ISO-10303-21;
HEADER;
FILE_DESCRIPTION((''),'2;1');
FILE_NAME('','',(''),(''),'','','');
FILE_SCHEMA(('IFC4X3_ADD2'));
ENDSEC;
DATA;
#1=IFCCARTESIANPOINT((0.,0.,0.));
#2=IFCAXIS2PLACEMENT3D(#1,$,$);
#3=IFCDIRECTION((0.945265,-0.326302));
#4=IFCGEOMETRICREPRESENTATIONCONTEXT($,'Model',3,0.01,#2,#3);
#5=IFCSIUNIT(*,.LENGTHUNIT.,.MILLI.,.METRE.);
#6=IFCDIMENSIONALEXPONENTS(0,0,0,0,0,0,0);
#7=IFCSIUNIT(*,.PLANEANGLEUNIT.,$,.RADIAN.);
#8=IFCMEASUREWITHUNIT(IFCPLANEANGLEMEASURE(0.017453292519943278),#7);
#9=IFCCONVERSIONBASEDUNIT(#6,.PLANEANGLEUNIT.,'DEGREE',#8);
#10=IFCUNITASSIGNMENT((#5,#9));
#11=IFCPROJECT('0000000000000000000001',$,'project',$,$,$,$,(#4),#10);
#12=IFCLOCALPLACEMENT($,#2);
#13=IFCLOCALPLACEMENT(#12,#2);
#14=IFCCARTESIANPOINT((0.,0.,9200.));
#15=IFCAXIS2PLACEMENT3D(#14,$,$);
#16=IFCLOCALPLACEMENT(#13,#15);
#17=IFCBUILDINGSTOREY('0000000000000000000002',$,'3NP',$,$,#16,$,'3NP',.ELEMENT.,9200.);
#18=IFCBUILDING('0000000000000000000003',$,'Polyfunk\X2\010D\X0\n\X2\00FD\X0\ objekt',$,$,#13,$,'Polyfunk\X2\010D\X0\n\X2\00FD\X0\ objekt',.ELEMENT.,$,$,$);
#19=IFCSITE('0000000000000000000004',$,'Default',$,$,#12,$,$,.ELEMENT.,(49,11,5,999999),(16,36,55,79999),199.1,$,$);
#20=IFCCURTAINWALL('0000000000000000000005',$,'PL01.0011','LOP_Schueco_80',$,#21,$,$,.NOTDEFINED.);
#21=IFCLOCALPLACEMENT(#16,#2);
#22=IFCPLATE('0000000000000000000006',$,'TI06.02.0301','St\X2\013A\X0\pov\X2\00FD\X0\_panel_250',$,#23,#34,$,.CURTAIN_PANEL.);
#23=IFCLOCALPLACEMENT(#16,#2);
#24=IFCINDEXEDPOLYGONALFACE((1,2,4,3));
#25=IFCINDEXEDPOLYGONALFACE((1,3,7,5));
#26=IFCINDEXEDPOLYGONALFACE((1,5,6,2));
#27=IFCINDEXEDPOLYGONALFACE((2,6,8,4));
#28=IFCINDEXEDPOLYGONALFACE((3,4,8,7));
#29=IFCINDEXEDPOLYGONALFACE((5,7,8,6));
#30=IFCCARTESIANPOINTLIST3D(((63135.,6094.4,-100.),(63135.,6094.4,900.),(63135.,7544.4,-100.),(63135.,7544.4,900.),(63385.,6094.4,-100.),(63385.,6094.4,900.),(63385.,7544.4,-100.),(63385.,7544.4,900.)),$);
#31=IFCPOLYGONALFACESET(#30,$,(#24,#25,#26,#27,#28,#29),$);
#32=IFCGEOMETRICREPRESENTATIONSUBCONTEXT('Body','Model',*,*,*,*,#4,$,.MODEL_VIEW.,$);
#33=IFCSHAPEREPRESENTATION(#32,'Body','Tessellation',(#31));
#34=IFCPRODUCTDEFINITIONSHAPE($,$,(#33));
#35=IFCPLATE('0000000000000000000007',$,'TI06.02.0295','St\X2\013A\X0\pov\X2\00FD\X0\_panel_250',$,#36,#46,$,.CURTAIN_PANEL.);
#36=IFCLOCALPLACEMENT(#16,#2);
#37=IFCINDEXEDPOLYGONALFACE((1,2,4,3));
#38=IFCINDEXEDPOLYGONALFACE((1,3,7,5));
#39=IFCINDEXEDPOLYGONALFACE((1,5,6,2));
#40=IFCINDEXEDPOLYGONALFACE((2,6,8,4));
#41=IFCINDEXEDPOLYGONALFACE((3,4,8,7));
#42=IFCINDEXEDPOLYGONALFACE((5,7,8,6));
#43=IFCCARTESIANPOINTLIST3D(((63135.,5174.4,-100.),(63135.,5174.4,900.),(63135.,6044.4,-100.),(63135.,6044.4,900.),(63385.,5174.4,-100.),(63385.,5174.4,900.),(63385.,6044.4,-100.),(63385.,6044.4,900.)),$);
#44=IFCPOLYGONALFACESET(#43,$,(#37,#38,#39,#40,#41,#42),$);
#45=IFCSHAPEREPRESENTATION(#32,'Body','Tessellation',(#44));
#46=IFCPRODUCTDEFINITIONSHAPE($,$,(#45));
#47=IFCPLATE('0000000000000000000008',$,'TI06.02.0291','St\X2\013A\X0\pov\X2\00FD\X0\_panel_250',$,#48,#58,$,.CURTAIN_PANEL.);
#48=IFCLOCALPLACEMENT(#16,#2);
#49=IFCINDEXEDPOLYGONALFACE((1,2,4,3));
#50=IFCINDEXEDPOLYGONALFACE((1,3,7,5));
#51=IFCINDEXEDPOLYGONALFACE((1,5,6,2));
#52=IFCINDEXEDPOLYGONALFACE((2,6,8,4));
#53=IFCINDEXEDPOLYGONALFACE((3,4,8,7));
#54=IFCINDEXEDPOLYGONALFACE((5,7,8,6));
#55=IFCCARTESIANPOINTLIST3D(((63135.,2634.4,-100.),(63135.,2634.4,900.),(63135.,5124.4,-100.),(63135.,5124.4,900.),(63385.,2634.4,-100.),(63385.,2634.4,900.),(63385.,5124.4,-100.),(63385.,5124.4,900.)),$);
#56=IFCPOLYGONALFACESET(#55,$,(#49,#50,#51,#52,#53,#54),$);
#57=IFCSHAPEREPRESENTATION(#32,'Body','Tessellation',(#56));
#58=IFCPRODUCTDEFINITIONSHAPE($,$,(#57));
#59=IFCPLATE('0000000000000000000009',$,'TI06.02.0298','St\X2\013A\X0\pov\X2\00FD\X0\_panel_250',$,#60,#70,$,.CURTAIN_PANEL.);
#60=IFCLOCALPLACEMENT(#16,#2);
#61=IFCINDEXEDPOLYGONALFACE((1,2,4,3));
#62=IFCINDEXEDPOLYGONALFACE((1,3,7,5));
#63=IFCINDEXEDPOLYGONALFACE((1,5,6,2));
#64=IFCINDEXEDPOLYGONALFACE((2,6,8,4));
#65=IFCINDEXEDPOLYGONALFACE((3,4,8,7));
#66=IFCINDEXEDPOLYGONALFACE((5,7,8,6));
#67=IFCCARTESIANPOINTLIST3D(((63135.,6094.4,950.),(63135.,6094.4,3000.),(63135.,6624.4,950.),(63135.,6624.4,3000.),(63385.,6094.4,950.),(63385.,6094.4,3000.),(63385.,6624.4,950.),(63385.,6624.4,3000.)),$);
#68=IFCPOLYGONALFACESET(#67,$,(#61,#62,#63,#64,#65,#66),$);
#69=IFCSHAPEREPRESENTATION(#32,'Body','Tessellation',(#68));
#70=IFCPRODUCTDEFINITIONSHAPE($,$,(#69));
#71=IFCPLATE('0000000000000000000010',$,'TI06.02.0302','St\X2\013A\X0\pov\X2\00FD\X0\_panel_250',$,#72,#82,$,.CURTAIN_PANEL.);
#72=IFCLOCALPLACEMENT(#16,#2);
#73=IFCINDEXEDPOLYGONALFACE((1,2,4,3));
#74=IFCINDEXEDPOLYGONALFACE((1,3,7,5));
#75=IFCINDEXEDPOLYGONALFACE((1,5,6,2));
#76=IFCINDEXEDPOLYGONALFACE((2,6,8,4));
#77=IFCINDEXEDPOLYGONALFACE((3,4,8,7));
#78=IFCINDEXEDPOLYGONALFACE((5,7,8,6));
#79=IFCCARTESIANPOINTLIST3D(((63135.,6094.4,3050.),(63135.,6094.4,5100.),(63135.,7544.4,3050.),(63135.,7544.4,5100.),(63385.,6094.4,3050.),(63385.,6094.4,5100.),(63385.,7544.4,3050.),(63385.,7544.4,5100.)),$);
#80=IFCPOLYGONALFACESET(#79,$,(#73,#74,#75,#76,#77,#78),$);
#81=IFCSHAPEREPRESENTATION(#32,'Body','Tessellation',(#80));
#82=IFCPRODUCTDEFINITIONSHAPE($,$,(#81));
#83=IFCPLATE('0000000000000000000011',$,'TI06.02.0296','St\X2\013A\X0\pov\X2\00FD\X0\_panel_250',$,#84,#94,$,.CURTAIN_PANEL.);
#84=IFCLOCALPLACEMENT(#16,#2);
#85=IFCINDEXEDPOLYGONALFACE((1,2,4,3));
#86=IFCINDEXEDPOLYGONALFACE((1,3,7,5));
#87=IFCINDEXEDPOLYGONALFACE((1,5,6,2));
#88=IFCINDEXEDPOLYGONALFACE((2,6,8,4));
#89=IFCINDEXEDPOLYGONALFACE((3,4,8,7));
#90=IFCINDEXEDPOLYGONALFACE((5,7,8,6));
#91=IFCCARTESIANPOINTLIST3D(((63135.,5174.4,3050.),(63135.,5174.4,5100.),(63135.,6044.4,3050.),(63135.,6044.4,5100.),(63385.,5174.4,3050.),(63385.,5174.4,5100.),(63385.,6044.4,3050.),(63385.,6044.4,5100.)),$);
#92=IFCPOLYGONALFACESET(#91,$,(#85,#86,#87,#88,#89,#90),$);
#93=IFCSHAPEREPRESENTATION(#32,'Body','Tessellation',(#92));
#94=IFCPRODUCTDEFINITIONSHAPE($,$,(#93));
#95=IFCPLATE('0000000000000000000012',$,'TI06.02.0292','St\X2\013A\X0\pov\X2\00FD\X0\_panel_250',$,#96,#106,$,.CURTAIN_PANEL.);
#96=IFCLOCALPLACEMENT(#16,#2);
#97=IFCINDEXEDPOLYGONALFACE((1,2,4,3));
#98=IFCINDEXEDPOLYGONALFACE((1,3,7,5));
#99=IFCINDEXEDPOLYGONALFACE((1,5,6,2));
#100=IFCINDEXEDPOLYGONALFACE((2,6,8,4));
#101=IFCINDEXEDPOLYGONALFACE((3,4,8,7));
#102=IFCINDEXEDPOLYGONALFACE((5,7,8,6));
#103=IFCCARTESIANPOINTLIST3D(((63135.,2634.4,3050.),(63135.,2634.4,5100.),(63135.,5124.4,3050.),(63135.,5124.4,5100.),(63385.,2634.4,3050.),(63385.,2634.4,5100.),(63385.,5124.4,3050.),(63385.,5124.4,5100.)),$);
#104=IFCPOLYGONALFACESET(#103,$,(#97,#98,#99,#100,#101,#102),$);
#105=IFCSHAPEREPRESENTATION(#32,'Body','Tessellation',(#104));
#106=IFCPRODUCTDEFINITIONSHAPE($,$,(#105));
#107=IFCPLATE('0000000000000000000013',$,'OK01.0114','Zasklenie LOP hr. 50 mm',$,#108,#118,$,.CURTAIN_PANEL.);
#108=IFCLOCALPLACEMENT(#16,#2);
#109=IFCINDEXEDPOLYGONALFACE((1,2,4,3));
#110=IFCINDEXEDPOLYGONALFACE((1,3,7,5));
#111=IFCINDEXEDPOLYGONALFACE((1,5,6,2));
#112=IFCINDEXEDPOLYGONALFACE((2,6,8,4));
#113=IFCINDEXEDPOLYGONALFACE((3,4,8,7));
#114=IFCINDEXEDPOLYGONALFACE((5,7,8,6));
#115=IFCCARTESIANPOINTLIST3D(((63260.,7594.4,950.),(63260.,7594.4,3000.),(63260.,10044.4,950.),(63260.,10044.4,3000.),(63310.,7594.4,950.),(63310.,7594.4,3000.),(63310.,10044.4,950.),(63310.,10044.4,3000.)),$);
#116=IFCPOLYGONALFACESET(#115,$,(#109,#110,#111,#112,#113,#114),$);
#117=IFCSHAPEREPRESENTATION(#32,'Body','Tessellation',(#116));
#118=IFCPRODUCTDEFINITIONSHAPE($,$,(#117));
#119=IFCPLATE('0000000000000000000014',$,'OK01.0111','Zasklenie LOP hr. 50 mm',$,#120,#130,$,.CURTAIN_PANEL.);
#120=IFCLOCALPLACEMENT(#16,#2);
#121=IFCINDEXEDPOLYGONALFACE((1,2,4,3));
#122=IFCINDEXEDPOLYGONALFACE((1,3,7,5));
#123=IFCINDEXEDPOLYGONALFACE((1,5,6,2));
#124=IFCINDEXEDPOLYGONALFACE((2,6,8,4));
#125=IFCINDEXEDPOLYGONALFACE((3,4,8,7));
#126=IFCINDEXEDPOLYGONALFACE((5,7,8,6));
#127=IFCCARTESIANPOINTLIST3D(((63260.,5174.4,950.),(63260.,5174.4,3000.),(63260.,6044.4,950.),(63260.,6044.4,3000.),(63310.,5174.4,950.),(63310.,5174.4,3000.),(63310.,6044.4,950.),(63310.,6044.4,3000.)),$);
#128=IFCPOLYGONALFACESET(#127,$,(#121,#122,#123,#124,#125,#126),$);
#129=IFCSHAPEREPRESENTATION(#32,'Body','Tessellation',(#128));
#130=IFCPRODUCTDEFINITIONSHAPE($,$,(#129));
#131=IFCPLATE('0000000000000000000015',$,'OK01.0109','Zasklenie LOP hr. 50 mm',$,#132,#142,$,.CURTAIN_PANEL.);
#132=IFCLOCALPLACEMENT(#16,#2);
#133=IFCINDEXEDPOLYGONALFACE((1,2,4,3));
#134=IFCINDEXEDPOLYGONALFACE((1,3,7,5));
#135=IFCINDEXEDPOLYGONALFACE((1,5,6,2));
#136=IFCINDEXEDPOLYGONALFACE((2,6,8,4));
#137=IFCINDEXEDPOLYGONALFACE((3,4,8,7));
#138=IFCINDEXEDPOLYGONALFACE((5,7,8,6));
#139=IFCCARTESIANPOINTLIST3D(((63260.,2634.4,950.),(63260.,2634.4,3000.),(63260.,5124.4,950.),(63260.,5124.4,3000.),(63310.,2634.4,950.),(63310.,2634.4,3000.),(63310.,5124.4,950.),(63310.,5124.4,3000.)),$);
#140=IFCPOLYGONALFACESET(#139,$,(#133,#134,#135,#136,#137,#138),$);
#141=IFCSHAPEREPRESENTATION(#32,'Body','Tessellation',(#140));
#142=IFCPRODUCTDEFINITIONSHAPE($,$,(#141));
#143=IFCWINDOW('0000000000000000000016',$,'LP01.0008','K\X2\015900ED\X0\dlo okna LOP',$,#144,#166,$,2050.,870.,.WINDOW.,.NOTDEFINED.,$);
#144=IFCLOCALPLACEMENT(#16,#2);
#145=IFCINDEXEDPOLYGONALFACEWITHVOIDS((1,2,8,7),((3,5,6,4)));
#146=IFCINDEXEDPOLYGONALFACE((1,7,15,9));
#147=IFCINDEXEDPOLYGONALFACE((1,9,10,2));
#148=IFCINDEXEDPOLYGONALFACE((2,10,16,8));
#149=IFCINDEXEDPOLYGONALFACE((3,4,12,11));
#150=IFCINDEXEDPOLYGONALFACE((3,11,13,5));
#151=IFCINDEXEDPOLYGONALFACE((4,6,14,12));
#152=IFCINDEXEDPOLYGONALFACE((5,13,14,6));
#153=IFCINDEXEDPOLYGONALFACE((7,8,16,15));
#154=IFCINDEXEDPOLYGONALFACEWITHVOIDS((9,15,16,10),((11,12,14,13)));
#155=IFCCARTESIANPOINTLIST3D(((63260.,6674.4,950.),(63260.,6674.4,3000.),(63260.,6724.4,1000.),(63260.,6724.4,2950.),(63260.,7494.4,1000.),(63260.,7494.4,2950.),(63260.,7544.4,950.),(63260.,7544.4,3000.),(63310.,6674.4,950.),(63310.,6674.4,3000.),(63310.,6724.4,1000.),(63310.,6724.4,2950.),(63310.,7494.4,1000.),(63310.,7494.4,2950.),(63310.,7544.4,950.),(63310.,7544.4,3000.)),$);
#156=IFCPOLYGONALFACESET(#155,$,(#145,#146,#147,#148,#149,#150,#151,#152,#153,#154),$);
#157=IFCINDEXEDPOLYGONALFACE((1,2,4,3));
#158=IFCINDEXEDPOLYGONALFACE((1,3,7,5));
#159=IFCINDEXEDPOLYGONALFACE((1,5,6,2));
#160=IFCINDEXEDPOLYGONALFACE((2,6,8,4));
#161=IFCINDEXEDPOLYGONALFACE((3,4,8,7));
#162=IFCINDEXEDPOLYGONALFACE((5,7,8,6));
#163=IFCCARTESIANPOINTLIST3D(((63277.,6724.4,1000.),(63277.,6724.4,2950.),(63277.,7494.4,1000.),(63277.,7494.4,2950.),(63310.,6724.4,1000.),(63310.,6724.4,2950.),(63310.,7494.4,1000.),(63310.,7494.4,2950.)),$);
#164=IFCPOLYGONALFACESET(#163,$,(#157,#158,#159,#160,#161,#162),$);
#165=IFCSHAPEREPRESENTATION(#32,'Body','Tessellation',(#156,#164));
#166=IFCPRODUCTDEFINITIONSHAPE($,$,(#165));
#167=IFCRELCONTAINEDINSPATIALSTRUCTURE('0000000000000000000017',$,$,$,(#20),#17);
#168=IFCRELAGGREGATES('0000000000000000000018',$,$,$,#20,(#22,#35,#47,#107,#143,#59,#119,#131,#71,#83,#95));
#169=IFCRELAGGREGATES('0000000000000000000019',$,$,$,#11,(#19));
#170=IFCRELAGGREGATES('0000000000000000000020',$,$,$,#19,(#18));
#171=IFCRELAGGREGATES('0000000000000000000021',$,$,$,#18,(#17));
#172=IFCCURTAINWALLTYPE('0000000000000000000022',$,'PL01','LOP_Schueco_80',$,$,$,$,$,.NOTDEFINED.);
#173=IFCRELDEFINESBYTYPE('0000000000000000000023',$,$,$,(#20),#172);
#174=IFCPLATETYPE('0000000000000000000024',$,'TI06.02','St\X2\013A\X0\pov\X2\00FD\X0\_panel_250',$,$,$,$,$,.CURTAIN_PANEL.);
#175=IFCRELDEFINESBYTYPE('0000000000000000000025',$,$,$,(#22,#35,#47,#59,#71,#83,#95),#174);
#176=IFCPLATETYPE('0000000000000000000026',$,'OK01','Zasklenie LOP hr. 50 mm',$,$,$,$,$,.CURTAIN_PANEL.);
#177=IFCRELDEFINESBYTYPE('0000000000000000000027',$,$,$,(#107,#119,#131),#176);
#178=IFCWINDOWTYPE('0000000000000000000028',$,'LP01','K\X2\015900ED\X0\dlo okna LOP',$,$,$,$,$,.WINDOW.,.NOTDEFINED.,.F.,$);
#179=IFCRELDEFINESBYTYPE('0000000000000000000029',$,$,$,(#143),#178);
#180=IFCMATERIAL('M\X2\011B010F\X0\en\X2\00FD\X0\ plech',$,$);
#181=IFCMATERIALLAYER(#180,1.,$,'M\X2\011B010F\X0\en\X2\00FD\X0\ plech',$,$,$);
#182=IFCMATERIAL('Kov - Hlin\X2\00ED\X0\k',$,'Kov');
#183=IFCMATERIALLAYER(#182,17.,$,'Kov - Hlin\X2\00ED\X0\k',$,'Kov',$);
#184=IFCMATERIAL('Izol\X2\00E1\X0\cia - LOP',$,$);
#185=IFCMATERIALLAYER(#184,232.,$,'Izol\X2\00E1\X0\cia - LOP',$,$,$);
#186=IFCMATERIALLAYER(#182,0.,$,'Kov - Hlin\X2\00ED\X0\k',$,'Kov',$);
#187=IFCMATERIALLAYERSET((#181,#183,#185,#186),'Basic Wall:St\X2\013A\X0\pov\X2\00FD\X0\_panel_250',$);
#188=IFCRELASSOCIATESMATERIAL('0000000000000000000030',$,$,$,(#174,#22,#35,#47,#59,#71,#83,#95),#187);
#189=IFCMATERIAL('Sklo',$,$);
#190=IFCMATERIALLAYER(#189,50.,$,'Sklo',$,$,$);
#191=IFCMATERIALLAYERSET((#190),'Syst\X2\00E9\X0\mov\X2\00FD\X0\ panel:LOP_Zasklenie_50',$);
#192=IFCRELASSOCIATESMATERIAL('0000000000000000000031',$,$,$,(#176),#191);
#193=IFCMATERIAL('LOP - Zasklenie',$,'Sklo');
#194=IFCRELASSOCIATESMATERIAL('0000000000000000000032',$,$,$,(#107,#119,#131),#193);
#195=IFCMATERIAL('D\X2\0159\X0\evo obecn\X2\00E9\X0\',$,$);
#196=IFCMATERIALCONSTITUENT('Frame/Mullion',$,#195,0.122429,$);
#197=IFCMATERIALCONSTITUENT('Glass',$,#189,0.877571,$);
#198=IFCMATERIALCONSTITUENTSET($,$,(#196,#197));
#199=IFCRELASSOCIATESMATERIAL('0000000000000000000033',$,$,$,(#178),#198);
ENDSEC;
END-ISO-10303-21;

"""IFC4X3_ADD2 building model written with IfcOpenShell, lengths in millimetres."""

from ifc_helpers import new_model, entity, si_unit, converted_unit, direction, frame, frame_2d, origin, origin_2d_with_axis, place, context, subcontext, project, spatial, polyline, rectangle, outline, extrude, source, transform, mapped, material, layer, layer_set, layer_usage, constituent, constituent_set, type_object, type_shapes, element, aggregate, save


model = new_model("IFC4X3_ADD2")

# Units and contexts
model_context = context("Model", 3, precision=0.01, world=origin(), true_north=direction((0.945265, -0.326302)))
body_context = subcontext(model_context, "Body", "Model", "MODEL_VIEW")
ifc_project = project(units=[si_unit("LENGTHUNIT", "METRE", prefix="MILLI"), converted_unit("PLANEANGLEUNIT", "DEGREE", entity("IfcPlaneAngleMeasure", 0.017453292519943278), si_unit("PLANEANGLEUNIT", "RADIAN"), dimensions=[0, 0, 0, 0, 0, 0, 0])], contexts=[model_context])

# Site, building, storey
site_placement = place(None, origin())
site = spatial("IfcSite", under=ifc_project, at=site_placement, Name="Default", CompositionType="ELEMENT", RefLatitude=(49, 11, 5, 999999), RefLongitude=(16, 36, 55, 79999), RefElevation=199.1)
building_placement = place(site_placement, origin())
building = spatial("IfcBuilding", under=site, at=building_placement, Name="Polyfunkčný objekt", LongName="Polyfunkčný objekt", CompositionType="ELEMENT")
storey_placement = place(building_placement, frame((0.0, 0.0, 9200.0)))
storey = spatial("IfcBuildingStorey", under=building, at=storey_placement, Name="3NP", LongName="3NP", CompositionType="ELEMENT", Elevation=9200.0)

# Curtain wall, plates, window
curtain_wall_type = type_object("IfcCurtainWallType", Name="PL01", Description="LOP_Schueco_80", PredefinedType="NOTDEFINED")
curtain_wall_placement = place(storey_placement, frame((0.0, 0.0, -9200.0)))
curtain_wall = element("IfcCurtainWall", 1, at=curtain_wall_placement, inside=storey, type_object=curtain_wall_type, Name="PL01.0011", Description="LOP_Schueco_80", PredefinedType="NOTDEFINED")
ifc_material_1 = material(Name="Měďený plech")
ifc_layer_1 = layer(ifc_material_1, 1.0, Name="Měďený plech")
ifc_material_2 = material(Name="Kov - Hliník", Category="Kov")
ifc_layer_2 = layer(ifc_material_2, 17.0, Name="Kov - Hliník", Category="Kov")
ifc_material_3 = material(Name="Izolácia - LOP")
ifc_layer_3 = layer(ifc_material_3, 232.0, Name="Izolácia - LOP")
ifc_layer_4 = layer(ifc_material_2, 0.0, Name="Kov - Hliník", Category="Kov")
ifc_layer_set_1 = layer_set([ifc_layer_1, ifc_layer_2, ifc_layer_3, ifc_layer_4], Name="Basic Wall:Stĺpový_panel_250")
ifc_layer_usage_1 = layer_usage(ifc_layer_set_1, "AXIS2", "NEGATIVE", 125.0)
plate_type_1 = type_object("IfcPlateType", Name="TI06.02", Description="Stĺpový_panel_250", PredefinedType="CURTAIN_PANEL", material=ifc_layer_set_1)
plate_1_placement = place(storey_placement, frame((63260.0, 7544.4, -100.0), z_axis=(0.0, 0.0, 1.0), x_axis=(0.0, -1.0, 0.0)))
plate_1 = element("IfcPlate", 2, at=plate_1_placement, type_object=plate_type_1, material=ifc_layer_usage_1, Name="TI06.02.0301", Description="Stĺpový_panel_250", PredefinedType="CURTAIN_PANEL", context=body_context, shape_type="SweptSolid", body=[
    extrude(rectangle(XDim=250.0, YDim=1450.0, at=frame_2d((0.0, 0.0), x_axis=(1.0, 0.0))), frame((725.0, 0.0, 0.0), z_axis=(0.0, 0.0, 1.0), x_axis=(0.0, 1.0, 0.0)), (0.0, 0.0, 1.0), 1000.0),
])
ifc_layer_usage_2 = layer_usage(ifc_layer_set_1, "AXIS2", "NEGATIVE", 125.0)
plate_2_placement = place(storey_placement, frame((63260.0, 6044.4, -100.0), z_axis=(0.0, 0.0, 1.0), x_axis=(0.0, -1.0, 0.0)))
plate_2 = element("IfcPlate", 3, at=plate_2_placement, type_object=plate_type_1, material=ifc_layer_usage_2, Name="TI06.02.0295", Description="Stĺpový_panel_250", PredefinedType="CURTAIN_PANEL", context=body_context, shape_type="SweptSolid", body=[
    extrude(rectangle(XDim=250.0, YDim=870.0, at=frame_2d((0.0, 0.0), x_axis=(1.0, 0.0))), frame((435.0, 0.0, 0.0), z_axis=(0.0, 0.0, 1.0), x_axis=(0.0, 1.0, 0.0)), (0.0, 0.0, 1.0), 1000.0),
])
ifc_layer_usage_3 = layer_usage(ifc_layer_set_1, "AXIS2", "NEGATIVE", 125.0)
plate_3_placement = place(storey_placement, frame((63260.0, 5124.4, -100.0), z_axis=(0.0, 0.0, 1.0), x_axis=(0.0, -1.0, 0.0)))
plate_3 = element("IfcPlate", 4, at=plate_3_placement, type_object=plate_type_1, material=ifc_layer_usage_3, Name="TI06.02.0291", Description="Stĺpový_panel_250", PredefinedType="CURTAIN_PANEL", context=body_context, shape_type="SweptSolid", body=[
    extrude(rectangle(XDim=250.0, YDim=2490.0, at=origin_2d_with_axis()), frame((1245.0, 0.0, 0.0), z_axis=(0.0, 0.0, 1.0), x_axis=(0.0, 1.0, 0.0)), (0.0, 0.0, 1.0), 1000.0),
])
ifc_layer_usage_4 = layer_usage(ifc_layer_set_1, "AXIS2", "NEGATIVE", 125.0)
plate_4_placement = place(storey_placement, frame((63260.0, 6624.4, 950.0), z_axis=(0.0, 0.0, 1.0), x_axis=(0.0, -1.0, 0.0)))
plate_4 = element("IfcPlate", 5, at=plate_4_placement, type_object=plate_type_1, material=ifc_layer_usage_4, Name="TI06.02.0298", Description="Stĺpový_panel_250", PredefinedType="CURTAIN_PANEL", context=body_context, shape_type="SweptSolid", body=[
    extrude(rectangle(XDim=250.0, YDim=530.0, at=frame_2d((0.0, 0.0), x_axis=(1.0, 0.0))), frame((265.0, 0.0, 0.0), z_axis=(0.0, 0.0, 1.0), x_axis=(0.0, 1.0, 0.0)), (0.0, 0.0, 1.0), 2050.0),
])
ifc_layer_usage_5 = layer_usage(ifc_layer_set_1, "AXIS2", "NEGATIVE", 125.0)
plate_5_placement = place(storey_placement, frame((63260.0, 7544.4, 3050.0), z_axis=(0.0, 0.0, 1.0), x_axis=(0.0, -1.0, 0.0)))
plate_5 = element("IfcPlate", 6, at=plate_5_placement, type_object=plate_type_1, material=ifc_layer_usage_5, Name="TI06.02.0302", Description="Stĺpový_panel_250", PredefinedType="CURTAIN_PANEL", context=body_context, shape_type="SweptSolid", body=[
    extrude(rectangle(XDim=250.0, YDim=1450.0, at=frame_2d((0.0, 0.0), x_axis=(1.0, 0.0))), frame((725.0, 0.0, 0.0), z_axis=(0.0, 0.0, 1.0), x_axis=(0.0, 1.0, 0.0)), (0.0, 0.0, 1.0), 2050.0),
])
ifc_layer_usage_6 = layer_usage(ifc_layer_set_1, "AXIS2", "NEGATIVE", 125.0)
plate_6_placement = place(storey_placement, frame((63260.0, 6044.4, 3050.0), z_axis=(0.0, 0.0, 1.0), x_axis=(0.0, -1.0, 0.0)))
plate_6 = element("IfcPlate", 7, at=plate_6_placement, type_object=plate_type_1, material=ifc_layer_usage_6, Name="TI06.02.0296", Description="Stĺpový_panel_250", PredefinedType="CURTAIN_PANEL", context=body_context, shape_type="SweptSolid", body=[
    extrude(rectangle(XDim=250.0, YDim=870.0, at=frame_2d((0.0, 0.0), x_axis=(1.0, 0.0))), frame((435.0, 0.0, 0.0), z_axis=(0.0, 0.0, 1.0), x_axis=(0.0, 1.0, 0.0)), (0.0, 0.0, 1.0), 2050.0),
])
ifc_layer_usage_7 = layer_usage(ifc_layer_set_1, "AXIS2", "NEGATIVE", 125.0)
plate_7_placement = place(storey_placement, frame((63260.0, 5124.4, 3050.0), z_axis=(0.0, 0.0, 1.0), x_axis=(0.0, -1.0, 0.0)))
plate_7 = element("IfcPlate", 8, at=plate_7_placement, type_object=plate_type_1, material=ifc_layer_usage_7, Name="TI06.02.0292", Description="Stĺpový_panel_250", PredefinedType="CURTAIN_PANEL", context=body_context, shape_type="SweptSolid", body=[
    extrude(rectangle(XDim=250.0, YDim=2490.0, at=frame_2d((0.0, 0.0), x_axis=(1.0, 0.0))), frame((1245.0, 0.0, 0.0), z_axis=(0.0, 0.0, 1.0), x_axis=(0.0, 1.0, 0.0)), (0.0, 0.0, 1.0), 2050.0),
])
ifc_material_4 = material(Name="LOP - Zasklenie", Category="Sklo")
ifc_material_5 = material(Name="Sklo")
ifc_layer_5 = layer(ifc_material_5, 50.0, Name="Sklo")
ifc_layer_set_2 = layer_set([ifc_layer_5], Name="Systémový panel:LOP_Zasklenie_50")
plate_type_2 = type_object("IfcPlateType", Name="OK01", Description="Zasklenie LOP hr. 50 mm", PredefinedType="CURTAIN_PANEL", material=ifc_layer_set_2)
shared_shape_1 = source(origin(), body_context, "Body", "SweptSolid", [
    extrude(rectangle(XDim=50.0, YDim=2450.0, at=origin_2d_with_axis()), frame((0.0, 25.0, 0.0), z_axis=(0.0, 0.0, 1.0), x_axis=(0.0, 1.0, 0.0)), (0.0, 0.0, 1.0), 2050.0),
])
plate_8_placement = place(curtain_wall_placement, frame((63260.0, 8819.4, 10150.0), z_axis=(0.0, 0.0, 1.0), x_axis=(0.0, -1.0, 0.0)))
plate_8 = element("IfcPlate", 9, at=plate_8_placement, type_object=plate_type_2, material=ifc_material_4, Name="OK01.0114", Description="Zasklenie LOP hr. 50 mm", PredefinedType="CURTAIN_PANEL", context=body_context, shape_type="MappedRepresentation", body=[
    mapped(shared_shape_1, transform((0.0, 0.0, 0.0), scale=1.0)),
])
shared_shape_2 = source(origin(), body_context, "Body", "SweptSolid", [
    extrude(rectangle(XDim=50.0, YDim=870.0, at=origin_2d_with_axis()), frame((0.0, 25.0, 0.0), z_axis=(0.0, 0.0, 1.0), x_axis=(0.0, 1.0, 0.0)), (0.0, 0.0, 1.0), 2050.0),
])
plate_9_placement = place(curtain_wall_placement, frame((63260.0, 5609.4, 10150.0), z_axis=(0.0, 0.0, 1.0), x_axis=(0.0, -1.0, 0.0)))
plate_9 = element("IfcPlate", 10, at=plate_9_placement, type_object=plate_type_2, material=ifc_material_4, Name="OK01.0111", Description="Zasklenie LOP hr. 50 mm", PredefinedType="CURTAIN_PANEL", context=body_context, shape_type="MappedRepresentation", body=[
    mapped(shared_shape_2, transform((0.0, 0.0, 0.0), scale=1.0)),
])
shared_shape_3 = source(origin(), body_context, "Body", "SweptSolid", [
    extrude(rectangle(XDim=50.0, YDim=2490.0, at=origin_2d_with_axis()), frame((0.0, 25.0, 0.0), z_axis=(0.0, 0.0, 1.0), x_axis=(0.0, 1.0, 0.0)), (0.0, 0.0, 1.0), 2050.0),
])
type_shapes(plate_type_2, [shared_shape_1, shared_shape_2, shared_shape_3])
plate_10_placement = place(curtain_wall_placement, frame((63260.0, 3879.4, 10150.0), z_axis=(0.0, 0.0, 1.0), x_axis=(0.0, -1.0, 0.0)))
plate_10 = element("IfcPlate", 11, at=plate_10_placement, type_object=plate_type_2, material=ifc_material_4, Name="OK01.0109", Description="Zasklenie LOP hr. 50 mm", PredefinedType="CURTAIN_PANEL", context=body_context, shape_type="MappedRepresentation", body=[
    mapped(shared_shape_3, transform((0.0, 0.0, 0.0), scale=1.0)),
])
ifc_material_6 = material(Name="Dřevo obecné")
ifc_constituent_1 = constituent(ifc_material_6, Name="Frame/Mullion", fraction=0.122429)
ifc_constituent_2 = constituent(ifc_material_5, Name="Glass", fraction=0.877571)
ifc_constituent_set = constituent_set(constituents=[ifc_constituent_1, ifc_constituent_2])
window_type = type_object("IfcWindowType", Name="LP01", Description="Křídlo okna LOP", ParameterTakesPrecedence=False, PartitioningType="NOTDEFINED", PredefinedType="WINDOW", material=ifc_constituent_set)
shared_shape_4 = source(origin(), body_context, "Body", "SweptSolid", [
    extrude(outline(polyline([(-1025.0, -435.0), (1025.0, -435.0), (1025.0, 435.0), (-1025.0, 435.0), (-1025.0, -435.0)]), holes=[polyline([(-975.0, -385.0), (-975.0, 385.0), (975.0, 385.0), (975.0, -385.0), (-975.0, -385.0)])]), frame((0.0, 0.0, 1025.0), z_axis=(0.0, 1.0, 0.0), x_axis=(0.0, 0.0, -1.0)), (0.0, 0.0, 1.0), 50.0),
    extrude(rectangle(XDim=33.0, YDim=770.0, at=origin_2d_with_axis()), frame((0.0, 33.5, 50.0), z_axis=(0.0, 0.0, 1.0), x_axis=(0.0, -1.0, 0.0)), (0.0, 0.0, 1.0), 1950.0),
])
type_shapes(window_type, [shared_shape_4])
window_placement = place(curtain_wall_placement, frame((63260.0, 7109.4, 10150.0), z_axis=(0.0, 0.0, 1.0), x_axis=(0.0, -1.0, 0.0)))
window = element("IfcWindow", 12, at=window_placement, type_object=window_type, Name="LP01.0008", Description="Křídlo okna LOP", OverallHeight=2050.0, OverallWidth=870.0, PartitioningType="NOTDEFINED", PredefinedType="WINDOW", context=body_context, shape_type="MappedRepresentation", body=[
    mapped(shared_shape_4, transform((0.0, 0.0, 0.0), scale=1.0)),
])
aggregate(curtain_wall, [plate_1, plate_2, plate_3, plate_8, window, plate_4, plate_9, plate_10, plate_5, plate_6, plate_7])

save(model, "model.ifc")
